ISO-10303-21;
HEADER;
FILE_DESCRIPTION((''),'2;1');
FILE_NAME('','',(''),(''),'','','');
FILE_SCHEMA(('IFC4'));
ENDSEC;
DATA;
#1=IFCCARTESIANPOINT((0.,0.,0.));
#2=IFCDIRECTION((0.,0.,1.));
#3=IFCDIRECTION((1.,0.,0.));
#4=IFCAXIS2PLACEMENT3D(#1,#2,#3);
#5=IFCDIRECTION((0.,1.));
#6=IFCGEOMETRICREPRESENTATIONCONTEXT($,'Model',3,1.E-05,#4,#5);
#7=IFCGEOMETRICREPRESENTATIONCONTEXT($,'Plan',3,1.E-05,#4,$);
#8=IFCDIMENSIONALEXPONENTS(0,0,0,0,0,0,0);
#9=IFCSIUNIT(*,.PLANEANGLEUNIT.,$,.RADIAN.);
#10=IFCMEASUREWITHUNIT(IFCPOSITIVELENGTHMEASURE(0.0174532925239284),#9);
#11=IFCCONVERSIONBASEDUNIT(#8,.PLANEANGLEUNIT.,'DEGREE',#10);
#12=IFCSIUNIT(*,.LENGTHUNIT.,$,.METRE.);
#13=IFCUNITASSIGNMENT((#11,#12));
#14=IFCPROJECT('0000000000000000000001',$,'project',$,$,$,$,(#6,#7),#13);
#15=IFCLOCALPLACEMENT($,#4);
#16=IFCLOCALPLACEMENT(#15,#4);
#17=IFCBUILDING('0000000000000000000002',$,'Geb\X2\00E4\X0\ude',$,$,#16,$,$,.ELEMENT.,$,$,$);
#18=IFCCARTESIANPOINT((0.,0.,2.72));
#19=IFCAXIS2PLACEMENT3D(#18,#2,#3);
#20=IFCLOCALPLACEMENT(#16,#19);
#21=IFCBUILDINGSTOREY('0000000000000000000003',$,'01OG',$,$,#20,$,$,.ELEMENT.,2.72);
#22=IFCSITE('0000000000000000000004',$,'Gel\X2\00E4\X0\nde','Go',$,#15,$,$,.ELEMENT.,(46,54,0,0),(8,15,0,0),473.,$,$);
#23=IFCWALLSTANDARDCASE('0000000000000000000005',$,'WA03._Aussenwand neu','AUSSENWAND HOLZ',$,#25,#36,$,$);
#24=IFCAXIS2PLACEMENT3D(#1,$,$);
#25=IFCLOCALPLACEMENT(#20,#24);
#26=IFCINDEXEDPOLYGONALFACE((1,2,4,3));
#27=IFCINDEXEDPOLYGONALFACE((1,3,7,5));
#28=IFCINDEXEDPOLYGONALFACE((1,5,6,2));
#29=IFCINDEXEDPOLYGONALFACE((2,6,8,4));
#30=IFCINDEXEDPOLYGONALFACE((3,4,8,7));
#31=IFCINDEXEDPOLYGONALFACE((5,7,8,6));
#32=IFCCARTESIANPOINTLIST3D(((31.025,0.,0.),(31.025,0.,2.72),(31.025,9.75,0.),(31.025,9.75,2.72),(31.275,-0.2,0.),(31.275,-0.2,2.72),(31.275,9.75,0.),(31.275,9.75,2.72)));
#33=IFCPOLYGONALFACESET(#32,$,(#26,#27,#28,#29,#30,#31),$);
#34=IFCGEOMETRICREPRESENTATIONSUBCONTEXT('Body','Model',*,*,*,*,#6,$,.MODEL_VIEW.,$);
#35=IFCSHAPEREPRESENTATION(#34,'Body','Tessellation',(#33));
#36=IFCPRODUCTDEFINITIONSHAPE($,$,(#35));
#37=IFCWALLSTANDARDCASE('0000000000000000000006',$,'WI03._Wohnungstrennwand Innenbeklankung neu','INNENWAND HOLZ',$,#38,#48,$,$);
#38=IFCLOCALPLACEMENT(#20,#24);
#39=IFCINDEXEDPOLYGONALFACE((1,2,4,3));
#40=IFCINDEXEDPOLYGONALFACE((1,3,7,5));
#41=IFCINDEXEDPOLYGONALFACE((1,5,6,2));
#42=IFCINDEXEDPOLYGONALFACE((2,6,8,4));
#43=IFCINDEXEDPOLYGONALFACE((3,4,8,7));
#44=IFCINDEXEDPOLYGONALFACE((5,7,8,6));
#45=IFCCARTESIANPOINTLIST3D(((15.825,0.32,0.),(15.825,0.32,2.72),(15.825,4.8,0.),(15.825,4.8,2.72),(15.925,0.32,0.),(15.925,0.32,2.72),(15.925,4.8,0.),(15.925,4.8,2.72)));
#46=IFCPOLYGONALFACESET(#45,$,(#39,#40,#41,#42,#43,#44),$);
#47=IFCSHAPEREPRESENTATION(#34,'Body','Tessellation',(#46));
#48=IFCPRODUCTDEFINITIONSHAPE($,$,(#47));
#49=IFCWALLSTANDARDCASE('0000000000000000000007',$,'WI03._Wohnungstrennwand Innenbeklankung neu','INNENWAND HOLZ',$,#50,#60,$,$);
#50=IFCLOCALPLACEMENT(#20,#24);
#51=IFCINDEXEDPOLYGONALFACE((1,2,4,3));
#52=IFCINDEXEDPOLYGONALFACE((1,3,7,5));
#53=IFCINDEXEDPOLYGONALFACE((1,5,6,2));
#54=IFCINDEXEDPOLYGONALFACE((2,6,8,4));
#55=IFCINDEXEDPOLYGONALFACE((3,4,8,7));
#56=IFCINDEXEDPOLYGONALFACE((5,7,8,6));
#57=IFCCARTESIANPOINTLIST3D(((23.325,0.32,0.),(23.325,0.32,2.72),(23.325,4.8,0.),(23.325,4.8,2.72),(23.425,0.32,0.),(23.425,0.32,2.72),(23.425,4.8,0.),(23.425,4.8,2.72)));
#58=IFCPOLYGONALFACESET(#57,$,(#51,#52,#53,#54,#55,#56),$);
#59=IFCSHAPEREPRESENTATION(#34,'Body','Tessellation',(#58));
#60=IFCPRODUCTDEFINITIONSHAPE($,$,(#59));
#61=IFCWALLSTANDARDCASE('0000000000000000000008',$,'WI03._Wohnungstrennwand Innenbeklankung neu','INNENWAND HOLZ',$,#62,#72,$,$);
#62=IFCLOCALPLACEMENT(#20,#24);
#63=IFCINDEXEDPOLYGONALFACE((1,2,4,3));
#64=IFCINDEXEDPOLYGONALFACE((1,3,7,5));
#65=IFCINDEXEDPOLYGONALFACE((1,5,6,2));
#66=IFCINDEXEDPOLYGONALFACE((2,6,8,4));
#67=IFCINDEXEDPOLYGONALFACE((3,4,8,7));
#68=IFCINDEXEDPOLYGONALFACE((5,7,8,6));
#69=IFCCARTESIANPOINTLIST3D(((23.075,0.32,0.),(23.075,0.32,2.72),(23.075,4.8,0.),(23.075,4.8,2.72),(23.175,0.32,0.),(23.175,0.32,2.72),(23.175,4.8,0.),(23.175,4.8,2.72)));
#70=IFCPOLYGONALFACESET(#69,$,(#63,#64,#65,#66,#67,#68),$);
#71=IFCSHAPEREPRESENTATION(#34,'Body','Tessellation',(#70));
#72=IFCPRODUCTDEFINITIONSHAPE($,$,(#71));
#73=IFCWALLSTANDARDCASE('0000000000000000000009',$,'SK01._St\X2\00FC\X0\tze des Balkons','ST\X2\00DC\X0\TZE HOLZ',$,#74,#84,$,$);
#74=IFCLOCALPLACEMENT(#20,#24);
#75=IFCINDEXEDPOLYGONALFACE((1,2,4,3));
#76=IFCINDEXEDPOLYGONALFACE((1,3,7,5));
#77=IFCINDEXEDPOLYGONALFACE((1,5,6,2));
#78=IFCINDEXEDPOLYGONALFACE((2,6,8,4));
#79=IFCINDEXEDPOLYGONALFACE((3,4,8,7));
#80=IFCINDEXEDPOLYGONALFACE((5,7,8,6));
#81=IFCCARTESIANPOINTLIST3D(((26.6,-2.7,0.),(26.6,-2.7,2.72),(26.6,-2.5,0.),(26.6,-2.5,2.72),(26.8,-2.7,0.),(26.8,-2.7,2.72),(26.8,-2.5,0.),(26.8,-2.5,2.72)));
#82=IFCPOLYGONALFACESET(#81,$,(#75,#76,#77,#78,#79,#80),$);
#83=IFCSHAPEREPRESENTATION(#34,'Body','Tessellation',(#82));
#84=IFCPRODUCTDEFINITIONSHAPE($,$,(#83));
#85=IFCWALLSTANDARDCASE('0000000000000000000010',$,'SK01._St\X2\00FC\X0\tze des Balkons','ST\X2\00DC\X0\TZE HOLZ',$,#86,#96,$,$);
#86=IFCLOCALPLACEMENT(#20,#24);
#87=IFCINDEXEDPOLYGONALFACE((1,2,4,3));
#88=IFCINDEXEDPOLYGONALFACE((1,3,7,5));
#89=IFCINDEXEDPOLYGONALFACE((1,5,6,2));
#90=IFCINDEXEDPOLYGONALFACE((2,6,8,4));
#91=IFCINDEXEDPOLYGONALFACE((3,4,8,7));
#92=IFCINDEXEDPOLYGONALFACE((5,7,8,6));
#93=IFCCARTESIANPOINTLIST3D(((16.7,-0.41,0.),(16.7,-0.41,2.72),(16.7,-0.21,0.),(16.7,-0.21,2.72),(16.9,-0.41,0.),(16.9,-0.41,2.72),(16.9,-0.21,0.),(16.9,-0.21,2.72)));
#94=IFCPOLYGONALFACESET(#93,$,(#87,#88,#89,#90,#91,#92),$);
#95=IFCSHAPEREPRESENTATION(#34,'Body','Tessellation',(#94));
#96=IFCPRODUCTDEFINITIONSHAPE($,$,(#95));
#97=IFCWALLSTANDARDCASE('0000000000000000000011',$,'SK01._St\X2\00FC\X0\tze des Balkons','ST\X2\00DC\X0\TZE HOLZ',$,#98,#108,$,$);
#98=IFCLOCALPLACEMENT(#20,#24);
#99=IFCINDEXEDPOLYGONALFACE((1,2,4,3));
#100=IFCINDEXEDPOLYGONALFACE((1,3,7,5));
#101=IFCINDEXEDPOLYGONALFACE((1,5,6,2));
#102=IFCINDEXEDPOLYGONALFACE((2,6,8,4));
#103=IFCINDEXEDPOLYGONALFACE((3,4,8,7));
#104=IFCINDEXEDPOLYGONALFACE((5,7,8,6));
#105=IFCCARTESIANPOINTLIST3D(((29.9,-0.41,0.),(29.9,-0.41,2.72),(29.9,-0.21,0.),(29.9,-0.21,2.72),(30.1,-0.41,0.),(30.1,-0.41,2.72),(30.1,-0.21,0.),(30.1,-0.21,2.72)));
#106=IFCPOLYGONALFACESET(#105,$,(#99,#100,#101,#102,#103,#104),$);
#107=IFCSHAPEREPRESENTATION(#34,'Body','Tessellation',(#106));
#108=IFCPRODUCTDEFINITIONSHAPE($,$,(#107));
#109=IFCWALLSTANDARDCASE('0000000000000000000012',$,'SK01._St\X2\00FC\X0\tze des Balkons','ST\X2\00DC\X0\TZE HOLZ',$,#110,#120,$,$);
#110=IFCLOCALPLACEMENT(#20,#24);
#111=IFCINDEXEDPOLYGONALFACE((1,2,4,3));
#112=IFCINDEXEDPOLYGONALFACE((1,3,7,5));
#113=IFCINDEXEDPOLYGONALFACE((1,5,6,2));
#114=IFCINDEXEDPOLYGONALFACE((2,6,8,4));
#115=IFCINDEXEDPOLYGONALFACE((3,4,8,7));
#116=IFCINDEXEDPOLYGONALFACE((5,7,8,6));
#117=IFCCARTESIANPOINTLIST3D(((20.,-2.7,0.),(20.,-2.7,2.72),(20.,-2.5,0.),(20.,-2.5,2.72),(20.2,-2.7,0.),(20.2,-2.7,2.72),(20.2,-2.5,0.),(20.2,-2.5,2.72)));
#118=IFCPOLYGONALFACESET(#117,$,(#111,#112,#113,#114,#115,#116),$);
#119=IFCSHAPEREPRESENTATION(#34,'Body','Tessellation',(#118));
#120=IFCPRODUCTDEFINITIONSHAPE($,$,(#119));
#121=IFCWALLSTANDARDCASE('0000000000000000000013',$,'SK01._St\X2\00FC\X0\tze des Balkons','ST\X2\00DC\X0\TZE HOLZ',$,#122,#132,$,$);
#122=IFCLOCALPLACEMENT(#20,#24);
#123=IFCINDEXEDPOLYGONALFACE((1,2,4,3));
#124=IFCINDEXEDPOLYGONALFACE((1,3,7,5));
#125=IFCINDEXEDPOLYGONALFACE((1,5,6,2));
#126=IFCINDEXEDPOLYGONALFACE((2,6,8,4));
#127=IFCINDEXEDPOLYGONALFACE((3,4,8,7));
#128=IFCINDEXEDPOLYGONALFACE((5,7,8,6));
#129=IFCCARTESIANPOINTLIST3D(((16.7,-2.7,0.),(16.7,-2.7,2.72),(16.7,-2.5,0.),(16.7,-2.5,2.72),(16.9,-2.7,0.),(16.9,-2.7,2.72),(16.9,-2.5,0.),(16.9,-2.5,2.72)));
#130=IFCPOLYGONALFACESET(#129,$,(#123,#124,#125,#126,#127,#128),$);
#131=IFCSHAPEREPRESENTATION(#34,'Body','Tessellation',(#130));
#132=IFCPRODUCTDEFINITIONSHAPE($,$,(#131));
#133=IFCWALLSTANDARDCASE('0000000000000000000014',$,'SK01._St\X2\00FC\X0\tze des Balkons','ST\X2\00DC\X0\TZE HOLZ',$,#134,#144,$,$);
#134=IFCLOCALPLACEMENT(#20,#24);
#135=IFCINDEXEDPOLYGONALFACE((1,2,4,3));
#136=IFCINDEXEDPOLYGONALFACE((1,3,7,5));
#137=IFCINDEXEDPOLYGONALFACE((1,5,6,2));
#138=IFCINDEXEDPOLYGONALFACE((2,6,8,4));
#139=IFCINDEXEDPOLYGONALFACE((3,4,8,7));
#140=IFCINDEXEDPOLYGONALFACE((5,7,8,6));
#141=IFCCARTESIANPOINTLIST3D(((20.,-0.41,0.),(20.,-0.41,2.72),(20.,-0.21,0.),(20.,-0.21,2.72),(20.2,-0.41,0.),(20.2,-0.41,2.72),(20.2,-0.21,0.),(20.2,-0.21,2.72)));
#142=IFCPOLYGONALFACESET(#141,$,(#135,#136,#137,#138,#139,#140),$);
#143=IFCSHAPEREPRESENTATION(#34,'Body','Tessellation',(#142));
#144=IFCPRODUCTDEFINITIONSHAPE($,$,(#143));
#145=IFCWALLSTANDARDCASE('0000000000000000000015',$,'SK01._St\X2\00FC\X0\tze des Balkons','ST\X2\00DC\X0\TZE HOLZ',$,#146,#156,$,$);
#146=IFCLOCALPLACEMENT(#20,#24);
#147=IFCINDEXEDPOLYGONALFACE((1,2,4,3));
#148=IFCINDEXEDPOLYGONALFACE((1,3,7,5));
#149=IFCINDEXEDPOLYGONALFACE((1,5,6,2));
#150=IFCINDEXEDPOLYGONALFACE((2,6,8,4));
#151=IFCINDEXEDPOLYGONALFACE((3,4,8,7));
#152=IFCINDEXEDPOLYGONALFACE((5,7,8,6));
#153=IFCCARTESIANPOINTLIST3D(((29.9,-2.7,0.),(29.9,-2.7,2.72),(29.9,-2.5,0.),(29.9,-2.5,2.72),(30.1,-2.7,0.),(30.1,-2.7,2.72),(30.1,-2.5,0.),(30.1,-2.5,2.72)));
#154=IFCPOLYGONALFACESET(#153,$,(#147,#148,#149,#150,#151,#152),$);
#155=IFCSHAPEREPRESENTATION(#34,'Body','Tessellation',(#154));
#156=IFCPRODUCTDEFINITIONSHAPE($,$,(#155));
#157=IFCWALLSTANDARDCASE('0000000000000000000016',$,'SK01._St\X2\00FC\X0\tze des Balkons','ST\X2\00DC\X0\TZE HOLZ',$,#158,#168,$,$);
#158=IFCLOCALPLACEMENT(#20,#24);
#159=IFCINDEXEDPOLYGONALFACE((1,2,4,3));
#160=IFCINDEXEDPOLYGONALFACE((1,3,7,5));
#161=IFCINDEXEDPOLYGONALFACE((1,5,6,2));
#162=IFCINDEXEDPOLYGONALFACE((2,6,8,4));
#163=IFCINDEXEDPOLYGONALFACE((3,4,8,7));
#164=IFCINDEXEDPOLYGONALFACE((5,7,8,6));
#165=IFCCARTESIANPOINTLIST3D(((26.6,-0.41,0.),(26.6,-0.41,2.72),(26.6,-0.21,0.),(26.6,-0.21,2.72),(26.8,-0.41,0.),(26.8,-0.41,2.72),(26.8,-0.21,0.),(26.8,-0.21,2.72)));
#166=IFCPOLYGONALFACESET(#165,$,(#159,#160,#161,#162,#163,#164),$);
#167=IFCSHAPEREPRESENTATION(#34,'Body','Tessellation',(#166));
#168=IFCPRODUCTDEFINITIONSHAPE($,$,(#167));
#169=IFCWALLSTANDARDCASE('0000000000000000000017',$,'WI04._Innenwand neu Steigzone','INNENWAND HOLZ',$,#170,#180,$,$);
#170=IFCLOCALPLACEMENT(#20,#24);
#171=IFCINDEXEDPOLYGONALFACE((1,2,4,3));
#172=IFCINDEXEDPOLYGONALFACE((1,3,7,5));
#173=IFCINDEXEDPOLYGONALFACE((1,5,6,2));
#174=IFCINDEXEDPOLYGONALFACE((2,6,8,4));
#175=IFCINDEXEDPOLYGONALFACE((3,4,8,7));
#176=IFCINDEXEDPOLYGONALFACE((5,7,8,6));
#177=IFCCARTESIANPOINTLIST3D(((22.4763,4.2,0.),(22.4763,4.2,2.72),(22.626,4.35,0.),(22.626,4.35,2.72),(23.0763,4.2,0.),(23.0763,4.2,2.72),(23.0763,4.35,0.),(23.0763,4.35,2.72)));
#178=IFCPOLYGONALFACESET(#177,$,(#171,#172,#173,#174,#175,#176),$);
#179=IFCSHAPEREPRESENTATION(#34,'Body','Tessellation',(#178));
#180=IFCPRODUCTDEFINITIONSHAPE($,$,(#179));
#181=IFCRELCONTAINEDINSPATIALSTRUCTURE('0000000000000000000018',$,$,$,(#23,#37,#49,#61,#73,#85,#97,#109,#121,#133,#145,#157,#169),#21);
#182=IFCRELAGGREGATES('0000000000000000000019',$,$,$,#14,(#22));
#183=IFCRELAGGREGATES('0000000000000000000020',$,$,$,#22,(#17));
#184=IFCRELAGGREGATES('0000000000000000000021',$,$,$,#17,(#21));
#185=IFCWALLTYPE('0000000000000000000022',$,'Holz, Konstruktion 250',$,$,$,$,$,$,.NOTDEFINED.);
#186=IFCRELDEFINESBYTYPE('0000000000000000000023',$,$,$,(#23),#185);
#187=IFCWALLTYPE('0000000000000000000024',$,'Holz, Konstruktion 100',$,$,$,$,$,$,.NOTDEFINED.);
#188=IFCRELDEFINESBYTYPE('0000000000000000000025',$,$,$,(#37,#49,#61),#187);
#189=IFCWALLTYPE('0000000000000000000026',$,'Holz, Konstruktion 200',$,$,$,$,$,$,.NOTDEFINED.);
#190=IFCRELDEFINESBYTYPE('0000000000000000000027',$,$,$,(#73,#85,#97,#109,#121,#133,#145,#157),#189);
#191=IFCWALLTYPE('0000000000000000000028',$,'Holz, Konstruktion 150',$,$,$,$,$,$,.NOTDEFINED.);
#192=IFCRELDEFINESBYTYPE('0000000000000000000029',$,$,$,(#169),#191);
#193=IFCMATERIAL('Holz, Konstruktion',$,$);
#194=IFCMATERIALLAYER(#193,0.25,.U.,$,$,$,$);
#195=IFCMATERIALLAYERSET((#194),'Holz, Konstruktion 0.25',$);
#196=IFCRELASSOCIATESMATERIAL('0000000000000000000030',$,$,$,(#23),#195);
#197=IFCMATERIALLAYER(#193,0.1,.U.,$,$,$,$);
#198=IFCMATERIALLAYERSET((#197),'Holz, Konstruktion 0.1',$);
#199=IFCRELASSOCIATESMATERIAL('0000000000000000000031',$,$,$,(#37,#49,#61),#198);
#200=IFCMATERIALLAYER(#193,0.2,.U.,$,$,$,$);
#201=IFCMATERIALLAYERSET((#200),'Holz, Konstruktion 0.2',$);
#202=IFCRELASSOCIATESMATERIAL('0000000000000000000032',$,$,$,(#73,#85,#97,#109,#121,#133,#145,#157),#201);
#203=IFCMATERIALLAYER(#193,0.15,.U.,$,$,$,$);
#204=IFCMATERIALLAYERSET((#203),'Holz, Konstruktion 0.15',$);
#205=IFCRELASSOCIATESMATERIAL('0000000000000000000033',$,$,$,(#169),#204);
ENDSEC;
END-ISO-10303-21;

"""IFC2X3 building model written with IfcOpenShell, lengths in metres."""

from ifc_helpers import new_model, entity, si_unit, converted_unit, direction, frame, origin_with_axes, place, context, subcontext, project, spatial, polyline, outline, extrude, material, layer, layer_set, layer_usage, type_object, element, save


model = new_model("IFC2X3")

# Units and contexts
model_context = context("Model", 3, precision=1e-05, world=origin_with_axes(), true_north=direction((0.0, 1.0)))
plan_context = context("Plan", 3, precision=1e-05, world=origin_with_axes())
body_context = subcontext(model_context, "Body", "Model", "MODEL_VIEW")
ifc_project = project(units=[converted_unit("PLANEANGLEUNIT", "DEGREE", entity("IfcPositiveLengthMeasure", 0.0174532925239284), si_unit("PLANEANGLEUNIT", "RADIAN"), dimensions=[0, 0, 0, 0, 0, 0, 0]), si_unit("LENGTHUNIT", "METRE")], contexts=[model_context, plan_context])

# Site, building, storey
site_placement = place(None, origin_with_axes())
site = spatial("IfcSite", under=ifc_project, at=site_placement, Name="Gelände", Description="Go", CompositionType="ELEMENT", RefLatitude=(46, 54, 0, 0), RefLongitude=(8, 15, 0, 0), RefElevation=473.0)
building_placement = place(site_placement, origin_with_axes())
building = spatial("IfcBuilding", under=site, at=building_placement, Name="Gebäude", CompositionType="ELEMENT")
storey_placement = place(building_placement, frame((0.0, 0.0, 2.72), z_axis=(0.0, 0.0, 1.0), x_axis=(1.0, 0.0, 0.0)))
storey = spatial("IfcBuildingStorey", under=building, at=storey_placement, Name="01OG", CompositionType="ELEMENT", Elevation=2.72)

# Shared definitions
ifc_material_1 = material(Name="Holz, Konstruktion")

# Walls
ifc_layer_1 = layer(ifc_material_1, 0.25, ventilated="UNKNOWN")
ifc_layer_set_1 = layer_set([ifc_layer_1], Name="Holz, Konstruktion 0.25")
wall_type_1 = type_object("IfcWallType", Name="Holz, Konstruktion 250", PredefinedType="NOTDEFINED")
ifc_layer_usage_1 = layer_usage(ifc_layer_set_1, "AXIS2", "POSITIVE", 0.0)
wall_1_placement = place(storey_placement, frame((31.275, -0.2, 0.0), z_axis=(0.0, 0.0, 1.0), x_axis=(0.0, 1.0, 0.0)))
element("IfcWallStandardCase", 1, at=wall_1_placement, inside=storey, type_object=wall_type_1, material=ifc_layer_usage_1, Name="WA03._Aussenwand neu", Description="AUSSENWAND HOLZ", context=body_context, shape_type="SweptSolid", body=[
    extrude(outline(polyline([(0.0, 0.0), (9.95, 0.0), (9.95, 0.25), (0.2, 0.25), (0.0, 0.0)])), origin_with_axes(), (0.0, 0.0, 1.0), 2.72),
])
ifc_layer_2 = layer(ifc_material_1, 0.1, ventilated="UNKNOWN")
ifc_layer_set_2 = layer_set([ifc_layer_2], Name="Holz, Konstruktion 0.1")
ifc_layer_usage_2 = layer_usage(ifc_layer_set_2, "AXIS2", "NEGATIVE", 0.0)
wall_type_2 = type_object("IfcWallType", Name="Holz, Konstruktion 100", PredefinedType="NOTDEFINED")
wall_2_placement = place(storey_placement, frame((15.825, 0.32, 0.0), z_axis=(0.0, 0.0, 1.0), x_axis=(0.0, 1.0, 0.0)))
element("IfcWallStandardCase", 2, at=wall_2_placement, inside=storey, type_object=wall_type_2, material=ifc_layer_usage_2, Name="WI03._Wohnungstrennwand Innenbeklankung neu", Description="INNENWAND HOLZ", context=body_context, shape_type="SweptSolid", body=[
    extrude(outline(polyline([(0.0, -0.1), (4.48, -0.1), (4.48, 0.0), (0.0, 0.0), (0.0, -0.1)])), origin_with_axes(), (0.0, 0.0, 1.0), 2.72),
])
ifc_layer_usage_3 = layer_usage(ifc_layer_set_2, "AXIS2", "NEGATIVE", 0.0)
wall_3_placement = place(storey_placement, frame((23.325, 0.32, 0.0), z_axis=(0.0, 0.0, 1.0), x_axis=(0.0, 1.0, 0.0)))
element("IfcWallStandardCase", 3, at=wall_3_placement, inside=storey, type_object=wall_type_2, material=ifc_layer_usage_3, Name="WI03._Wohnungstrennwand Innenbeklankung neu", Description="INNENWAND HOLZ", context=body_context, shape_type="SweptSolid", body=[
    extrude(outline(polyline([(0.0, -0.1), (4.48, -0.1), (4.48, 0.0), (0.0, 0.0), (0.0, -0.1)])), origin_with_axes(), (0.0, 0.0, 1.0), 2.72),
])
ifc_layer_usage_4 = layer_usage(ifc_layer_set_2, "AXIS2", "POSITIVE", 0.0)
wall_4_placement = place(storey_placement, frame((23.175, 0.32, 0.0), z_axis=(0.0, 0.0, 1.0), x_axis=(0.0, 1.0, 0.0)))
element("IfcWallStandardCase", 4, at=wall_4_placement, inside=storey, type_object=wall_type_2, material=ifc_layer_usage_4, Name="WI03._Wohnungstrennwand Innenbeklankung neu", Description="INNENWAND HOLZ", context=body_context, shape_type="SweptSolid", body=[
    extrude(outline(polyline([(0.0, 0.0), (4.48, 0.0), (4.48, 0.1), (0.0, 0.1), (0.0, 0.0)])), origin_with_axes(), (0.0, 0.0, 1.0), 2.72),
])
ifc_layer_3 = layer(ifc_material_1, 0.2, ventilated="UNKNOWN")
ifc_layer_set_3 = layer_set([ifc_layer_3], Name="Holz, Konstruktion 0.2")
ifc_layer_usage_5 = layer_usage(ifc_layer_set_3, "AXIS2", "NEGATIVE", 0.0)
wall_type_3 = type_object("IfcWallType", Name="Holz, Konstruktion 200", PredefinedType="NOTDEFINED")
wall_5_placement = place(storey_placement, frame((26.6, -2.7, 0.0), z_axis=(0.0, 0.0, 1.0), x_axis=(0.0, 1.0, 0.0)))
element("IfcWallStandardCase", 5, at=wall_5_placement, inside=storey, type_object=wall_type_3, material=ifc_layer_usage_5, Name="SK01._Stütze des Balkons", Description="STÜTZE HOLZ", context=body_context, shape_type="SweptSolid", body=[
    extrude(outline(polyline([(0.0, -0.2), (0.2, -0.2), (0.2, 0.0), (0.0, 0.0), (0.0, -0.2)])), origin_with_axes(), (0.0, 0.0, 1.0), 2.72),
])
ifc_layer_usage_6 = layer_usage(ifc_layer_set_3, "AXIS2", "NEGATIVE", 0.0)
wall_6_placement = place(storey_placement, frame((16.7, -0.41, 0.0), z_axis=(0.0, 0.0, 1.0), x_axis=(0.0, 1.0, 0.0)))
element("IfcWallStandardCase", 6, at=wall_6_placement, inside=storey, type_object=wall_type_3, material=ifc_layer_usage_6, Name="SK01._Stütze des Balkons", Description="STÜTZE HOLZ", context=body_context, shape_type="SweptSolid", body=[
    extrude(outline(polyline([(0.0, -0.2), (0.2, -0.2), (0.2, 0.0), (0.0, 0.0), (0.0, -0.2)])), origin_with_axes(), (0.0, 0.0, 1.0), 2.72),
])
ifc_layer_usage_7 = layer_usage(ifc_layer_set_3, "AXIS2", "POSITIVE", 0.0)
wall_7_placement = place(storey_placement, frame((30.1, -0.41, 0.0), z_axis=(0.0, 0.0, 1.0), x_axis=(0.0, 1.0, 0.0)))
element("IfcWallStandardCase", 7, at=wall_7_placement, inside=storey, type_object=wall_type_3, material=ifc_layer_usage_7, Name="SK01._Stütze des Balkons", Description="STÜTZE HOLZ", context=body_context, shape_type="SweptSolid", body=[
    extrude(outline(polyline([(0.0, 0.0), (0.2, 0.0), (0.2, 0.2), (0.0, 0.2), (0.0, 0.0)])), origin_with_axes(), (0.0, 0.0, 1.0), 2.72),
])
ifc_layer_usage_8 = layer_usage(ifc_layer_set_3, "AXIS2", "POSITIVE", 0.0)
wall_8_placement = place(storey_placement, frame((20.2, -2.7, 0.0), z_axis=(0.0, 0.0, 1.0), x_axis=(0.0, 1.0, 0.0)))
element("IfcWallStandardCase", 8, at=wall_8_placement, inside=storey, type_object=wall_type_3, material=ifc_layer_usage_8, Name="SK01._Stütze des Balkons", Description="STÜTZE HOLZ", context=body_context, shape_type="SweptSolid", body=[
    extrude(outline(polyline([(0.0, 0.0), (0.2, 0.0), (0.2, 0.2), (0.0, 0.2), (0.0, 0.0)])), origin_with_axes(), (0.0, 0.0, 1.0), 2.72),
])
ifc_layer_usage_9 = layer_usage(ifc_layer_set_3, "AXIS2", "NEGATIVE", 0.0)
wall_9_placement = place(storey_placement, frame((16.7, -2.7, 0.0), z_axis=(0.0, 0.0, 1.0), x_axis=(0.0, 1.0, 0.0)))
element("IfcWallStandardCase", 9, at=wall_9_placement, inside=storey, type_object=wall_type_3, material=ifc_layer_usage_9, Name="SK01._Stütze des Balkons", Description="STÜTZE HOLZ", context=body_context, shape_type="SweptSolid", body=[
    extrude(outline(polyline([(0.0, -0.2), (0.2, -0.2), (0.2, 0.0), (0.0, 0.0), (0.0, -0.2)])), origin_with_axes(), (0.0, 0.0, 1.0), 2.72),
])
ifc_layer_usage_10 = layer_usage(ifc_layer_set_3, "AXIS2", "POSITIVE", 0.0)
wall_10_placement = place(storey_placement, frame((20.2, -0.41, 0.0), z_axis=(0.0, 0.0, 1.0), x_axis=(0.0, 1.0, 0.0)))
element("IfcWallStandardCase", 10, at=wall_10_placement, inside=storey, type_object=wall_type_3, material=ifc_layer_usage_10, Name="SK01._Stütze des Balkons", Description="STÜTZE HOLZ", context=body_context, shape_type="SweptSolid", body=[
    extrude(outline(polyline([(0.0, 0.0), (0.2, 0.0), (0.2, 0.2), (0.0, 0.2), (0.0, 0.0)])), origin_with_axes(), (0.0, 0.0, 1.0), 2.72),
])
ifc_layer_usage_11 = layer_usage(ifc_layer_set_3, "AXIS2", "POSITIVE", 0.0)
wall_11_placement = place(storey_placement, frame((30.1, -2.7, 0.0), z_axis=(0.0, 0.0, 1.0), x_axis=(0.0, 1.0, 0.0)))
element("IfcWallStandardCase", 11, at=wall_11_placement, inside=storey, type_object=wall_type_3, material=ifc_layer_usage_11, Name="SK01._Stütze des Balkons", Description="STÜTZE HOLZ", context=body_context, shape_type="SweptSolid", body=[
    extrude(outline(polyline([(0.0, 0.0), (0.2, 0.0), (0.2, 0.2), (0.0, 0.2), (0.0, 0.0)])), origin_with_axes(), (0.0, 0.0, 1.0), 2.72),
])
ifc_layer_usage_12 = layer_usage(ifc_layer_set_3, "AXIS2", "NEGATIVE", 0.0)
wall_12_placement = place(storey_placement, frame((26.6, -0.41, 0.0), z_axis=(0.0, 0.0, 1.0), x_axis=(0.0, 1.0, 0.0)))
element("IfcWallStandardCase", 12, at=wall_12_placement, inside=storey, type_object=wall_type_3, material=ifc_layer_usage_12, Name="SK01._Stütze des Balkons", Description="STÜTZE HOLZ", context=body_context, shape_type="SweptSolid", body=[
    extrude(outline(polyline([(0.0, -0.2), (0.2, -0.2), (0.2, 0.0), (0.0, 0.0), (0.0, -0.2)])), origin_with_axes(), (0.0, 0.0, 1.0), 2.72),
])
ifc_layer_4 = layer(ifc_material_1, 0.15, ventilated="UNKNOWN")
ifc_layer_set_4 = layer_set([ifc_layer_4], Name="Holz, Konstruktion 0.15")
ifc_layer_usage_13 = layer_usage(ifc_layer_set_4, "AXIS2", "POSITIVE", 0.0)
wall_type_4 = type_object("IfcWallType", Name="Holz, Konstruktion 150", PredefinedType="NOTDEFINED")
wall_13_placement = place(storey_placement, frame((22.4763, 4.2, 0.0), z_axis=(0.0, 0.0, 1.0), x_axis=(1.0, 0.0, 0.0)))
element("IfcWallStandardCase", 13, at=wall_13_placement, inside=storey, type_object=wall_type_4, material=ifc_layer_usage_13, Name="WI04._Innenwand neu Steigzone", Description="INNENWAND HOLZ", context=body_context, shape_type="SweptSolid", body=[
    extrude(outline(polyline([(0.0, 0.0), (0.6, 0.0), (0.6, 0.15), (0.1497, 0.15), (0.0, 0.0)])), origin_with_axes(), (0.0, 0.0, 1.0), 2.72),
])

save(model, "model.ifc")
